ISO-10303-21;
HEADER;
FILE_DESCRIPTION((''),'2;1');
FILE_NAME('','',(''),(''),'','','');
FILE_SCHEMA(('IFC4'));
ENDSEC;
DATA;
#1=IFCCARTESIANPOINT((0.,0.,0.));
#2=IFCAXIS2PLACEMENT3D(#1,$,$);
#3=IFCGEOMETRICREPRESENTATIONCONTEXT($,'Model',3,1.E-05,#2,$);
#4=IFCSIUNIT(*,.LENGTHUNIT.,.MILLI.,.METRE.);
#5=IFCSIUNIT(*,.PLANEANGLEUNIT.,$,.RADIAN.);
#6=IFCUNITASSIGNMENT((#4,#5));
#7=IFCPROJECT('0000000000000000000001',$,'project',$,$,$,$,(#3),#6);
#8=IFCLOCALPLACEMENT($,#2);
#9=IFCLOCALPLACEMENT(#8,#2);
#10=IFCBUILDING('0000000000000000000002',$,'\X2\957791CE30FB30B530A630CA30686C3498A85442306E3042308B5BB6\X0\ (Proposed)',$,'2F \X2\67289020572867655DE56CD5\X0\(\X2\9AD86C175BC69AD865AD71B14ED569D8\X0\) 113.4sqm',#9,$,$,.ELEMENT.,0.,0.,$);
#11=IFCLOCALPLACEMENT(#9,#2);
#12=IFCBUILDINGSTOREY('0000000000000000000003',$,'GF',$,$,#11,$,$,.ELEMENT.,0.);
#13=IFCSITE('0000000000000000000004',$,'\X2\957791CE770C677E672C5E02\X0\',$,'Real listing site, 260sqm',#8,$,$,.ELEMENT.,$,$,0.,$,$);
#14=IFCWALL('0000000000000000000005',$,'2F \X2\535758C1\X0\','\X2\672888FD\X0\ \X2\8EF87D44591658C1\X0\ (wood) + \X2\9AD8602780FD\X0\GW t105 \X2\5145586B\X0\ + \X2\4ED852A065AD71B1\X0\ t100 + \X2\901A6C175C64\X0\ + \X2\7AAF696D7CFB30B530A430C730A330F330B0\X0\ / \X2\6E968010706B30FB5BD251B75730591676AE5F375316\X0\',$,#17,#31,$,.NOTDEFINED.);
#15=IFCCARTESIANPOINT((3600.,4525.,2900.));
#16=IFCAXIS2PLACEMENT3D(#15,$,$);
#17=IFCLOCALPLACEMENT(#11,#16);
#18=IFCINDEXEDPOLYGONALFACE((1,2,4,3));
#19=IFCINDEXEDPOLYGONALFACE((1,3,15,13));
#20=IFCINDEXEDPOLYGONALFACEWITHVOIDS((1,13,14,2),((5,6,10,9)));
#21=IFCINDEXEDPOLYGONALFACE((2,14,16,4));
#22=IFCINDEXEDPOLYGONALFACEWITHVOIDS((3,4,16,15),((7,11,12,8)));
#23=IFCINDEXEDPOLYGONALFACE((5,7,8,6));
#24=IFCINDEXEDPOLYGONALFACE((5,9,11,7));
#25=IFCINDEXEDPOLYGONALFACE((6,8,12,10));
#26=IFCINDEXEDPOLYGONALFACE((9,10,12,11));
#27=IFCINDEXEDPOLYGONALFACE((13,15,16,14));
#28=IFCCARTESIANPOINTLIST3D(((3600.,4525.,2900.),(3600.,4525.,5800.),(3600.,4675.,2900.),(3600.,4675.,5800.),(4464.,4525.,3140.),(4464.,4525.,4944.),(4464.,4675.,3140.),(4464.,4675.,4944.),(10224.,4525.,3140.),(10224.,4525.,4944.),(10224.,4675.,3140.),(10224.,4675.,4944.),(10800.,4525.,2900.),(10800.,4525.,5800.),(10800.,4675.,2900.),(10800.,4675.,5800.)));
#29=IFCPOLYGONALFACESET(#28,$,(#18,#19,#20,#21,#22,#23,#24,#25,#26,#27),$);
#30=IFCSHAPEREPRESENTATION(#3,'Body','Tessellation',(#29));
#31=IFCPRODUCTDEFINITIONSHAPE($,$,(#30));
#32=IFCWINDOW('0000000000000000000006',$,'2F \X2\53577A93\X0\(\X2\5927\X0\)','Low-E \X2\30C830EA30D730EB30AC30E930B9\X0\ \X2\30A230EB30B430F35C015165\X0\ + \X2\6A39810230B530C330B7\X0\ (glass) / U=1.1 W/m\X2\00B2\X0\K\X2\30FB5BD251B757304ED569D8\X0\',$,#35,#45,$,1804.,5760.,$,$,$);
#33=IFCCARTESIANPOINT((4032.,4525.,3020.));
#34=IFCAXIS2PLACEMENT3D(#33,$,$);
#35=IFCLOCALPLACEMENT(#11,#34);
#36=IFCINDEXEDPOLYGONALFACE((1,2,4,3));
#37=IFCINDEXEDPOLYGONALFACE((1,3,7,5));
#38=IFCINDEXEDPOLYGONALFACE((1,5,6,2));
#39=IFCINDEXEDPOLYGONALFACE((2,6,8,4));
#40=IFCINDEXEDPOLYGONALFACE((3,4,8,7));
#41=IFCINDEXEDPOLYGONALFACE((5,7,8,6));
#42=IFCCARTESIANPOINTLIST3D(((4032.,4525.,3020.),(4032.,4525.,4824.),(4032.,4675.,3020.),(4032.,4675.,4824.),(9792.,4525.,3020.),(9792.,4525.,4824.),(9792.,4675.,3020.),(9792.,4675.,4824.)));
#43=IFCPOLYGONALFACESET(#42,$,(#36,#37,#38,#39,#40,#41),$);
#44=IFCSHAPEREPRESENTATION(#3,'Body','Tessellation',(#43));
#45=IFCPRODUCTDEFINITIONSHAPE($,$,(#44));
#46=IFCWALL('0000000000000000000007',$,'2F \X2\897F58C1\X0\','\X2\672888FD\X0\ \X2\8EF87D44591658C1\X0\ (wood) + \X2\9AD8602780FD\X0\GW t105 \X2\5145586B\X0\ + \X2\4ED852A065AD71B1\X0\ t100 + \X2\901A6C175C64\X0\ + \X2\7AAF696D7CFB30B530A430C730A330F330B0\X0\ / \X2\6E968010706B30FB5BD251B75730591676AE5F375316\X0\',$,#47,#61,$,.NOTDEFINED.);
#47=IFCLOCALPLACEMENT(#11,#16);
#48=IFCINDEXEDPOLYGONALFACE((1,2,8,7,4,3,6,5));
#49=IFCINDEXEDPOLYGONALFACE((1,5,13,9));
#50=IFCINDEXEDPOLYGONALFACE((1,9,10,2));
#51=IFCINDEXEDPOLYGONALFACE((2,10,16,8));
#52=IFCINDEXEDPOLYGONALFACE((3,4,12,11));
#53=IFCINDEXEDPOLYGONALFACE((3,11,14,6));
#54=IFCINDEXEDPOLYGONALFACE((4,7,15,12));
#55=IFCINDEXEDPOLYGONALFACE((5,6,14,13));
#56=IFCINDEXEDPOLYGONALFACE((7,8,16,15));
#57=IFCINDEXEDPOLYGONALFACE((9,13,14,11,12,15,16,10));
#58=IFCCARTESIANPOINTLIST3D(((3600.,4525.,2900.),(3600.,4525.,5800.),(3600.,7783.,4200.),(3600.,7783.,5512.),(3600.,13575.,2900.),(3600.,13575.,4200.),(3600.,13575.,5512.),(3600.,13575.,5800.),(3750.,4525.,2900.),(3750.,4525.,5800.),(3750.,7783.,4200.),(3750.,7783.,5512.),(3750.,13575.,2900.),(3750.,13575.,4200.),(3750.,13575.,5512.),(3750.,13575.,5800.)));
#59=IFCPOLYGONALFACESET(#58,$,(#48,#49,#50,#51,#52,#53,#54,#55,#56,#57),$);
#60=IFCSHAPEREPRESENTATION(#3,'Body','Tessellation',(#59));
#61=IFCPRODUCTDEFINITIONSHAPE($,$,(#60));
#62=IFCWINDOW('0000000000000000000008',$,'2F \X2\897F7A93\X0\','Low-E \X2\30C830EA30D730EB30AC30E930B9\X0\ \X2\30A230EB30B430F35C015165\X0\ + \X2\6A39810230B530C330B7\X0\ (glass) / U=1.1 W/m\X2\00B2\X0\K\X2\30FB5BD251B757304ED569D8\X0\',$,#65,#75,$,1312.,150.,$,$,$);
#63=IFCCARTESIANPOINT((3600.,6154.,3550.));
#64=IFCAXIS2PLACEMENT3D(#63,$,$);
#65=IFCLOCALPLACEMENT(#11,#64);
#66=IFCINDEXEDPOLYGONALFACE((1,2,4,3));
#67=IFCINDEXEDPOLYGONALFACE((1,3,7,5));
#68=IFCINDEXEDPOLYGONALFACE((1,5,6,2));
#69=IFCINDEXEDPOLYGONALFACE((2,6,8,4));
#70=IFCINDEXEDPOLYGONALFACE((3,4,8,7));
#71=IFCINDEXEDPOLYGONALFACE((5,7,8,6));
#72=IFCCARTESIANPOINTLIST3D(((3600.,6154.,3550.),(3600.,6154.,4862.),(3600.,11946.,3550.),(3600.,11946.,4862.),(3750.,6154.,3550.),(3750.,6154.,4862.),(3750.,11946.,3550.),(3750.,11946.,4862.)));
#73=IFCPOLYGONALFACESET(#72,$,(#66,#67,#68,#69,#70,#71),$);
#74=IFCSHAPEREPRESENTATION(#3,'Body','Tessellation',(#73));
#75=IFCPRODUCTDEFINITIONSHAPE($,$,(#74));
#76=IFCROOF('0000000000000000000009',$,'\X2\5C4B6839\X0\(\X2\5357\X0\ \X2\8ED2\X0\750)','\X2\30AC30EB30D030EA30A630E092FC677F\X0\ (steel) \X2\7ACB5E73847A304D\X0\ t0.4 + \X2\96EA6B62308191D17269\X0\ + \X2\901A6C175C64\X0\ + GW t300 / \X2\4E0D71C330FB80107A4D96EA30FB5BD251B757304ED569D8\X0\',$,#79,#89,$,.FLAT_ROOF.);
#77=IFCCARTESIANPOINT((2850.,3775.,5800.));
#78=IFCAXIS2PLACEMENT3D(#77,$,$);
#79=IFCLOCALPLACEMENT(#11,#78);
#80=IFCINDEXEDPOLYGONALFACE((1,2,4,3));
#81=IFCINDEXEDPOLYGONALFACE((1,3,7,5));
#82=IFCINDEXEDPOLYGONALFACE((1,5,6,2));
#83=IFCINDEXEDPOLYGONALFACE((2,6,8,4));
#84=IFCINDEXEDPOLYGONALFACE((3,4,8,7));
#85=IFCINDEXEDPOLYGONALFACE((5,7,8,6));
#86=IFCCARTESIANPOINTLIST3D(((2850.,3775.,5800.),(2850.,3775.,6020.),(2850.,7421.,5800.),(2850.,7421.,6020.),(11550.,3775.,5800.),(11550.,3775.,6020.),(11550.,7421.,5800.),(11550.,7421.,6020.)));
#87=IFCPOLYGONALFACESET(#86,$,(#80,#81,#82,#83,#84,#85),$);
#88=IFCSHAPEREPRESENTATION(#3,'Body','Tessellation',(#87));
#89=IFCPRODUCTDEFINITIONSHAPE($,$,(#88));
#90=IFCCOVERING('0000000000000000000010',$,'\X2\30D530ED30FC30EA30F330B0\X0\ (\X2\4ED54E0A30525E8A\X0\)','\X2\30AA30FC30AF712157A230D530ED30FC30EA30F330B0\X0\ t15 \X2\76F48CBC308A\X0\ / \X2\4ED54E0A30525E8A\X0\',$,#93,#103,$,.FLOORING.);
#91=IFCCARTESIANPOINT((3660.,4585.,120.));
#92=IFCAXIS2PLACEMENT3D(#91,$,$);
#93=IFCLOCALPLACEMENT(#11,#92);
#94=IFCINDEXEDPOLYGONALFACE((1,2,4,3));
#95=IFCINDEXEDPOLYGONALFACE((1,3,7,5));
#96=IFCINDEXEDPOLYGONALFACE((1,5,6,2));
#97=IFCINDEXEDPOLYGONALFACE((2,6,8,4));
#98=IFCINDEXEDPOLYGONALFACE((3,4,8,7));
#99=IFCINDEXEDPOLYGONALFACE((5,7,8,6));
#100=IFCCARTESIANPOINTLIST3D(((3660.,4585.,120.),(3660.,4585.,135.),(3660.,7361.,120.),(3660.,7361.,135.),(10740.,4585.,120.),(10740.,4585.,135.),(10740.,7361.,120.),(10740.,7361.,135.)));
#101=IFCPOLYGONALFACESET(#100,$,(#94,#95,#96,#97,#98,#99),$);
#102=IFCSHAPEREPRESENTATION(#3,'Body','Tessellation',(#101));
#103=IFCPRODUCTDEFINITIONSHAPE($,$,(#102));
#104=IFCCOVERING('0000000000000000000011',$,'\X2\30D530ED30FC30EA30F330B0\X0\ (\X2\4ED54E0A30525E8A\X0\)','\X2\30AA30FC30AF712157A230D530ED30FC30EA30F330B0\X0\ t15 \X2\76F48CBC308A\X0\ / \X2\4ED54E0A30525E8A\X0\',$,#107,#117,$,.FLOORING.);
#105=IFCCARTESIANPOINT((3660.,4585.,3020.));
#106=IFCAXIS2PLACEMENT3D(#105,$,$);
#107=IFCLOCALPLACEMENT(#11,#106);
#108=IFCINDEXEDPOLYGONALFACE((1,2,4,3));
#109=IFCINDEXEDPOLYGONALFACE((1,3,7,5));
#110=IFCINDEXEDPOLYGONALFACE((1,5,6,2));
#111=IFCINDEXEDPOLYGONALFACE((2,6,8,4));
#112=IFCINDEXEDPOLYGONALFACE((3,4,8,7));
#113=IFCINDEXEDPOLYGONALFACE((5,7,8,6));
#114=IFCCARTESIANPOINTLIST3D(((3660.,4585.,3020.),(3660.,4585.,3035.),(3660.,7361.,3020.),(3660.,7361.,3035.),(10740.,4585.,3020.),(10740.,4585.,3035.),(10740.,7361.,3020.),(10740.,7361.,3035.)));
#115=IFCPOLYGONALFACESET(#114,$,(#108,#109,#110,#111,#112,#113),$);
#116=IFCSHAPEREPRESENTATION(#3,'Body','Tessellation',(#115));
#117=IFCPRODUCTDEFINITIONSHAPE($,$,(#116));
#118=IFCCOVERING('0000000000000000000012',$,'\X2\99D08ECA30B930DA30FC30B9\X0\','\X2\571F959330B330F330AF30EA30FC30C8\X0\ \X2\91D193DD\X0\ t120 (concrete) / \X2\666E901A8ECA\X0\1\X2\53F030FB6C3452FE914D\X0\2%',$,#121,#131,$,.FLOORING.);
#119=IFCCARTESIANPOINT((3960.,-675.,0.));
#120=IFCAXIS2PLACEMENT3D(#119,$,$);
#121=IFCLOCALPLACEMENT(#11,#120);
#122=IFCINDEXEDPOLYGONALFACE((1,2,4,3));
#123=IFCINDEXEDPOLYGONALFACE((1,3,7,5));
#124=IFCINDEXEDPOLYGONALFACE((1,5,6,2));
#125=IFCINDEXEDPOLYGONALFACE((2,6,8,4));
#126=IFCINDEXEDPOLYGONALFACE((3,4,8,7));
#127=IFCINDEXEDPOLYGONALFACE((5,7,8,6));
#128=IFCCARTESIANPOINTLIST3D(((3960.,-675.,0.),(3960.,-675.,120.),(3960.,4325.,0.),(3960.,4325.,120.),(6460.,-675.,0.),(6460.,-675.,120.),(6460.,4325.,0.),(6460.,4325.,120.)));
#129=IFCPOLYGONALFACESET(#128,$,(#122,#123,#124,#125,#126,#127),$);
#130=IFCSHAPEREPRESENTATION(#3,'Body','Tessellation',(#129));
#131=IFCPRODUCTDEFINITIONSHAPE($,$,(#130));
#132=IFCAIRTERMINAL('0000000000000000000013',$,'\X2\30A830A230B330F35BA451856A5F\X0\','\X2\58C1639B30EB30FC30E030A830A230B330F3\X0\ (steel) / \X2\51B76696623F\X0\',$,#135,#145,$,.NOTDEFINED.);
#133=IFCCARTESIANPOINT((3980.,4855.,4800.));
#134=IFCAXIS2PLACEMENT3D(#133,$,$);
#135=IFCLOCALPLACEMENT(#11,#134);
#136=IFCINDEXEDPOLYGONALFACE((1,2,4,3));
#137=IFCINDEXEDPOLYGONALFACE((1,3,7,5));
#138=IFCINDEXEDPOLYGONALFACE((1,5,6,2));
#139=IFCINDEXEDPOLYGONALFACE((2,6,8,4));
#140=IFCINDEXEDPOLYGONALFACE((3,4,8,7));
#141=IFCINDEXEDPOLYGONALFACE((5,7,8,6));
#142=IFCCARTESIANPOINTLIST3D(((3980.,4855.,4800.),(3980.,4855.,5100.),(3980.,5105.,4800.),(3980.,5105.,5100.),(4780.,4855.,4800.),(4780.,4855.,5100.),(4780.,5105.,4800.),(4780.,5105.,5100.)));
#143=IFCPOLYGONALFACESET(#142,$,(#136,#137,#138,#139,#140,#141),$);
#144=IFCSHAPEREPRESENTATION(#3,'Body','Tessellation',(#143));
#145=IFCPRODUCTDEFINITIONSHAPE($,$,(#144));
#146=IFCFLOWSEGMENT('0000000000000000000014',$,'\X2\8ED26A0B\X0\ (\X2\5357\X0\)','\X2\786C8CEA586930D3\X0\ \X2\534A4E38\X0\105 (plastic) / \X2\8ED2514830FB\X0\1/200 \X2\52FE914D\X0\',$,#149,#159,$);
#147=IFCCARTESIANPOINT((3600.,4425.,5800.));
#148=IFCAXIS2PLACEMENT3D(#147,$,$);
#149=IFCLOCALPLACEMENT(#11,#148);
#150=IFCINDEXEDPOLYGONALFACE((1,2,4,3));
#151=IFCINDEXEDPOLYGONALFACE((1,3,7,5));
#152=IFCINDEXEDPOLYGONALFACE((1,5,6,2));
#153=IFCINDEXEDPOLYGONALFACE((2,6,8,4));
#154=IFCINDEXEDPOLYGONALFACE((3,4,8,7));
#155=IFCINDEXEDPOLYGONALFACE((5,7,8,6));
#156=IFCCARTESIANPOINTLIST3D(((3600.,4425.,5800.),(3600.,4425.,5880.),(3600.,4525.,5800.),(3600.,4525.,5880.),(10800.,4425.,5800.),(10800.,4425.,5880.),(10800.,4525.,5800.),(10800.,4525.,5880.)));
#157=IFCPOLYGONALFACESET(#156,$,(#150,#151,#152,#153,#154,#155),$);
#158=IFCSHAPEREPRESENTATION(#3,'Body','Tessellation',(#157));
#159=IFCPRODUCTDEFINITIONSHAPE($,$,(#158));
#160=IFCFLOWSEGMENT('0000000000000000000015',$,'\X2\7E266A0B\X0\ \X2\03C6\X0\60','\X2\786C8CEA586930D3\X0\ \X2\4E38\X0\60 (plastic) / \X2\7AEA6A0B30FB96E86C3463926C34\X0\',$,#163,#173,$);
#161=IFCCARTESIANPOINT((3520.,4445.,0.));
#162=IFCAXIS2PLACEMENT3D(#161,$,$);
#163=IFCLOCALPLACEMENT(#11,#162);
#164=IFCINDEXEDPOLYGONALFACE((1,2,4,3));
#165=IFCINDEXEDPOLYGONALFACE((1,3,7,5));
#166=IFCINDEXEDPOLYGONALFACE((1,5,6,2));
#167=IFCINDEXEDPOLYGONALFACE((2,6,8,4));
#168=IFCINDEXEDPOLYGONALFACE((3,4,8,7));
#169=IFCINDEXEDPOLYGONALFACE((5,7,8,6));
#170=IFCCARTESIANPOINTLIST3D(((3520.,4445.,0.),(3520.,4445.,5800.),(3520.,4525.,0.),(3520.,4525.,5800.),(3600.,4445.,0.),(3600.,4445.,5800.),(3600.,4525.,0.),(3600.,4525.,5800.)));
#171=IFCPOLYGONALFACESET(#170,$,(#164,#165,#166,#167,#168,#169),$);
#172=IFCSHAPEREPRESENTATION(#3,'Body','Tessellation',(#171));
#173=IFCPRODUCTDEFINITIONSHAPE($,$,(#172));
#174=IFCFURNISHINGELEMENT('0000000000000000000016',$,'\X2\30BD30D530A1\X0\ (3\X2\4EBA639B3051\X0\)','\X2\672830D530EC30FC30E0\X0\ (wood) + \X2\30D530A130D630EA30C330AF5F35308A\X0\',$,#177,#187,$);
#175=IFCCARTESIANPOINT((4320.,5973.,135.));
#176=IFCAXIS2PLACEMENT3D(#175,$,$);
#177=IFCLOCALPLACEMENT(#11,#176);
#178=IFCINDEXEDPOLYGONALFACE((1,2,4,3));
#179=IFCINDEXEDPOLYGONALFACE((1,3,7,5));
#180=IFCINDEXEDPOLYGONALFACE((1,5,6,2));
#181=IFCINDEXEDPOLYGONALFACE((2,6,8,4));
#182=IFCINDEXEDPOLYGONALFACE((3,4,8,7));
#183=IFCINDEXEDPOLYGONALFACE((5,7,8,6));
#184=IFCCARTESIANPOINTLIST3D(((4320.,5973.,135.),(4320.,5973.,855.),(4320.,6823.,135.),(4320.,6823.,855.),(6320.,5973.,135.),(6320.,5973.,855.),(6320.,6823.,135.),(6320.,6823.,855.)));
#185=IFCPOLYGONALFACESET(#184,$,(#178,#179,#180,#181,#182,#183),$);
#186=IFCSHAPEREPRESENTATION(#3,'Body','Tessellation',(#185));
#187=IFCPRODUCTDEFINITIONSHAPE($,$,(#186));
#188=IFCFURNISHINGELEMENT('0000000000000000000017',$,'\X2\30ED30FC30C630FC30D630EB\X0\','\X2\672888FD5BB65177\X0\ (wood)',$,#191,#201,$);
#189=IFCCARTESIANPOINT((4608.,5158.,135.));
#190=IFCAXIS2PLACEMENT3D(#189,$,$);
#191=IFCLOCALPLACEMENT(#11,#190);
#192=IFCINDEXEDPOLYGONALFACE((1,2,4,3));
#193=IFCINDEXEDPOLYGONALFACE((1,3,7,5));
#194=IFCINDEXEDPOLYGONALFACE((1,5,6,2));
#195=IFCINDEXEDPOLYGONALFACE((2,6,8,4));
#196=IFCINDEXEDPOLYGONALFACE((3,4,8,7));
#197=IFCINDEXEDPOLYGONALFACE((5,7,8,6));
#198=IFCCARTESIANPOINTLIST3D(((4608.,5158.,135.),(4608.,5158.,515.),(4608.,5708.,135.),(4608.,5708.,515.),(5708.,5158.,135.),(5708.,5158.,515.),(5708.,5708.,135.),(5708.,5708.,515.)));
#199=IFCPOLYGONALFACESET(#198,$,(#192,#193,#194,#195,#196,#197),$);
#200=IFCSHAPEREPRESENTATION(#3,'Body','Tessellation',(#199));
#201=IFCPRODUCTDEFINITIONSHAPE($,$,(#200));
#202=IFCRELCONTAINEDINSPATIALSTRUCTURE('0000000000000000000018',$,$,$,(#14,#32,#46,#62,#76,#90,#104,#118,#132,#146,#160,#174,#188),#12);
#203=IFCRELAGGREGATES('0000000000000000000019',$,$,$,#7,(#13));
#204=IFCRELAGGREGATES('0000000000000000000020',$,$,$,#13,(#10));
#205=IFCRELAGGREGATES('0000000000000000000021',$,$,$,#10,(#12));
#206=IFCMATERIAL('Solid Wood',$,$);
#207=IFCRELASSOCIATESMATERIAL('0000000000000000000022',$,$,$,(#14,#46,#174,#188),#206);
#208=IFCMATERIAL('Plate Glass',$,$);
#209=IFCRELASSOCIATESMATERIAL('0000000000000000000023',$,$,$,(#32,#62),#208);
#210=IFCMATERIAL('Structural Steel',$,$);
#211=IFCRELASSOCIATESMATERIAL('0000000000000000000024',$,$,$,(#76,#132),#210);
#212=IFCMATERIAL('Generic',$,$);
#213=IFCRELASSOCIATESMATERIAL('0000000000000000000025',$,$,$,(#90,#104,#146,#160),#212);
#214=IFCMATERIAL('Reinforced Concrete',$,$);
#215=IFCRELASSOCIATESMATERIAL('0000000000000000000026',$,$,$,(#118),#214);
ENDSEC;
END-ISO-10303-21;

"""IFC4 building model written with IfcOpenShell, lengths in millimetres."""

from ifc_helpers import new_model, si_unit, frame, frame_2d, origin, place, context, project, spatial, rectangle, extrude, material, element, fill, save


model = new_model("IFC4")

# Units and contexts
model_context = context("Model", 3, precision=1e-05, world=origin())
ifc_project = project(units=[si_unit("LENGTHUNIT", "METRE", prefix="MILLI"), si_unit("PLANEANGLEUNIT", "RADIAN")], contexts=[model_context])

# Site, building, storey
site_placement = place(None, origin())
site = spatial("IfcSite", under=ifc_project, at=site_placement, Name="長野県松本市", ObjectType="Real listing site, 260sqm", CompositionType="ELEMENT", RefElevation=0.0)
building_placement = place(site_placement, origin())
building = spatial("IfcBuilding", under=site, at=building_placement, Name="長野・サウナと水風呂のある家 (Proposed)", ObjectType="2F 木造在来工法(高気密高断熱仕様) 113.4sqm", CompositionType="ELEMENT", ElevationOfRefHeight=0.0, ElevationOfTerrain=0.0)
storey_placement = place(building_placement, origin())
storey = spatial("IfcBuildingStorey", under=building, at=storey_placement, Name="GF", CompositionType="ELEMENT", Elevation=0.0)

# Shared definitions
ifc_material_1 = material(Name="Solid Wood")

# Shared definitions
ifc_material_2 = material(Name="Reinforced Concrete")

# Shared definitions
ifc_material_3 = material(Name="Plate Glass")

# Walls, openings, windows
wall_1_placement = place(storey_placement, frame((3600.0, 4525.0, 2900.0)))
wall_1 = element("IfcWall", 1, at=wall_1_placement, inside=storey, material=ifc_material_1, Name="2F 南壁", Description="木製 軸組外壁 (wood) + 高性能GW t105 充填 + 付加断熱 t100 + 通気層 + 窯業系サイディング / 準耐火・寒冷地外皮強化", PredefinedType="NOTDEFINED", context=model_context, shape_type="SweptSolid", body=[
    extrude(rectangle(XDim=7200.0, YDim=150.0, at=frame_2d((3600.0, 75.0))), frame((3600.0, 4525.0, 2900.0)), (0.0, 0.0, 1.0), 2900.0),
])
opening_1_placement = place(storey_placement, frame((4032.0, 4525.0, 3020.0)))
opening_1 = element("IfcOpeningElement", 2, at=opening_1_placement, cuts=wall_1, PredefinedType="NOTDEFINED", context=model_context, shape_type="SweptSolid", body=[
    extrude(rectangle(XDim=5760.0, YDim=150.0, at=frame_2d((2880.0, 75.0))), frame((4032.0, 4525.0, 3020.0)), (0.0, 0.0, 1.0), 1804.0),
])
window_1_placement = place(storey_placement, frame((4032.0, 4525.0, 3020.0)))
window_1 = element("IfcWindow", 3, at=window_1_placement, inside=storey, material=ifc_material_3, Name="2F 南窓(大)", Description="Low-E トリプルガラス アルゴン封入 + 樹脂サッシ (glass) / U=1.1 W/m²K・寒冷地仕様", OverallHeight=1804.0, OverallWidth=5760.0, context=model_context, shape_type="SweptSolid", body=[
    extrude(rectangle(XDim=5760.0, YDim=150.0, at=frame_2d((2880.0, 75.0))), frame((4032.0, 4525.0, 3020.0)), (0.0, 0.0, 1.0), 1804.0),
])
fill(opening_1, window_1)
wall_2_placement = place(storey_placement, frame((3600.0, 4525.0, 2900.0)))
wall_2 = element("IfcWall", 4, at=wall_2_placement, inside=storey, material=ifc_material_1, Name="2F 西壁", Description="木製 軸組外壁 (wood) + 高性能GW t105 充填 + 付加断熱 t100 + 通気層 + 窯業系サイディング / 準耐火・寒冷地外皮強化", PredefinedType="NOTDEFINED", context=model_context, shape_type="SweptSolid", body=[
    extrude(rectangle(XDim=150.0, YDim=9050.0, at=frame_2d((75.0, 4525.0))), frame((3600.0, 4525.0, 2900.0)), (0.0, 0.0, 1.0), 2900.0),
])
opening_2_placement = place(storey_placement, frame((3600.0, 6154.0, 3550.0)))
opening_2 = element("IfcOpeningElement", 5, at=opening_2_placement, cuts=wall_2, PredefinedType="NOTDEFINED", context=model_context, shape_type="SweptSolid", body=[
    extrude(rectangle(XDim=150.0, YDim=5792.0, at=frame_2d((75.0, 2896.0))), frame((3600.0, 6154.0, 3550.0)), (0.0, 0.0, 1.0), 1312.0),
])
window_2_placement = place(storey_placement, frame((3600.0, 6154.0, 3550.0)))
window_2 = element("IfcWindow", 6, at=window_2_placement, inside=storey, material=ifc_material_3, Name="2F 西窓", Description="Low-E トリプルガラス アルゴン封入 + 樹脂サッシ (glass) / U=1.1 W/m²K・寒冷地仕様", OverallHeight=1312.0, OverallWidth=150.0, context=model_context, shape_type="SweptSolid", body=[
    extrude(rectangle(XDim=150.0, YDim=5792.0, at=frame_2d((75.0, 2896.0))), frame((3600.0, 6154.0, 3550.0)), (0.0, 0.0, 1.0), 1312.0),
])
fill(opening_2, window_2)

# Roof
ifc_material_4 = material(Name="Structural Steel")
for number, where, name in (
    (7, (2850.0, 3775.0, 5800.0), "屋根(南 軒750)"),
):
    element("IfcRoof", number, at=place(storey_placement, frame(where)), inside=storey, material=ifc_material_4, Name=name, Description="ガルバリウム鋼板 (steel) 立平葺き t0.4 + 雪止め金物 + 通気層 + GW t300 / 不燃・耐積雪・寒冷地仕様", PredefinedType="FLAT_ROOF", context=model_context, shape_type="SweptSolid", body=[
        extrude(rectangle(XDim=8700.0, YDim=3646.0, at=frame_2d((4350.0, 1823.0))), frame((2850.0, 3775.0, 5800.0)), (0.0, 0.0, 1.0), 220.0),
    ])

# Coverings
ifc_material_5 = material(Name="Generic")
covering_1_placement = place(storey_placement, frame((3660.0, 4585.0, 120.0)))
element("IfcCovering", 8, at=covering_1_placement, inside=storey, material=ifc_material_5, Name="フローリング (仕上げ床)", Description="オーク無垢フローリング t15 直貼り / 仕上げ床", PredefinedType="FLOORING", context=model_context, shape_type="SweptSolid", body=[
    extrude(rectangle(XDim=7080.0, YDim=2776.0, at=frame_2d((3540.0, 1388.0))), frame((3660.0, 4585.0, 120.0)), (0.0, 0.0, 1.0), 15.0),
])
covering_2_placement = place(storey_placement, frame((3660.0, 4585.0, 3020.0)))
element("IfcCovering", 9, at=covering_2_placement, inside=storey, material=ifc_material_5, Name="フローリング (仕上げ床)", Description="オーク無垢フローリング t15 直貼り / 仕上げ床", PredefinedType="FLOORING", context=model_context, shape_type="SweptSolid", body=[
    extrude(rectangle(XDim=7080.0, YDim=2776.0, at=frame_2d((3540.0, 1388.0))), frame((3660.0, 4585.0, 3020.0)), (0.0, 0.0, 1.0), 15.0),
])
covering_3_placement = place(storey_placement, frame((3960.0, -675.0, 0.0)))
element("IfcCovering", 10, at=covering_3_placement, inside=storey, material=ifc_material_2, Name="駐車スペース", Description="土間コンクリート 金鏝 t120 (concrete) / 普通車1台・水勾配2%", PredefinedType="FLOORING", context=model_context, shape_type="SweptSolid", body=[
    extrude(rectangle(XDim=2500.0, YDim=5000.0, at=frame_2d((1250.0, 2500.0))), frame((3960.0, -675.0, 0.0)), (0.0, 0.0, 1.0), 120.0),
])

# Air terminal
air_terminal_placement = place(storey_placement, frame((3980.0, 4855.0, 4800.0)))
element("IfcAirTerminal", 11, at=air_terminal_placement, inside=storey, material=ifc_material_4, Name="エアコン室内機", Description="壁掛ルームエアコン (steel) / 冷暖房", PredefinedType="NOTDEFINED", context=model_context, shape_type="SweptSolid", body=[
    extrude(rectangle(XDim=800.0, YDim=250.0, at=frame_2d((400.0, 125.0))), frame((3980.0, 4855.0, 4800.0)), (0.0, 0.0, 1.0), 300.0),
])

# Flow segments
flow_segment_1_placement = place(storey_placement, frame((3600.0, 4425.0, 5800.0)))
element("IfcFlowSegment", 12, at=flow_segment_1_placement, inside=storey, material=ifc_material_5, Name="軒樋 (南)", Description="硬質塩ビ 半丸105 (plastic) / 軒先・1/200 勾配", context=model_context, shape_type="SweptSolid", body=[
    extrude(rectangle(XDim=7200.0, YDim=100.0, at=frame_2d((3600.0, 50.0))), frame((3600.0, 4425.0, 5800.0)), (0.0, 0.0, 1.0), 80.0),
])
flow_segment_2_placement = place(storey_placement, frame((3520.0, 4445.0, 0.0)))
element("IfcFlowSegment", 13, at=flow_segment_2_placement, inside=storey, material=ifc_material_5, Name="縦樋 φ60", Description="硬質塩ビ 丸60 (plastic) / 竪樋・雨水排水", context=model_context, shape_type="SweptSolid", body=[
    extrude(rectangle(XDim=80.0, YDim=80.0, at=frame_2d((40.0, 40.0))), frame((3520.0, 4445.0, 0.0)), (0.0, 0.0, 1.0), 5800.0),
])

# Furnishing elements
furnishing_1_placement = place(storey_placement, frame((4320.0, 5973.0, 135.0)))
element("IfcFurnishingElement", 14, at=furnishing_1_placement, inside=storey, material=ifc_material_1, Name="ソファ (3人掛け)", Description="木フレーム (wood) + ファブリック張り", context=model_context, shape_type="SweptSolid", body=[
    extrude(rectangle(XDim=2000.0, YDim=850.0, at=frame_2d((1000.0, 425.0))), frame((4320.0, 5973.0, 135.0)), (0.0, 0.0, 1.0), 720.0),
])
furnishing_2_placement = place(storey_placement, frame((4608.0, 5158.0, 135.0)))
element("IfcFurnishingElement", 15, at=furnishing_2_placement, inside=storey, material=ifc_material_1, Name="ローテーブル", Description="木製家具 (wood)", context=model_context, shape_type="SweptSolid", body=[
    extrude(rectangle(XDim=1100.0, YDim=550.0, at=frame_2d((550.0, 275.0))), frame((4608.0, 5158.0, 135.0)), (0.0, 0.0, 1.0), 380.0),
])

save(model, "model.ifc")
